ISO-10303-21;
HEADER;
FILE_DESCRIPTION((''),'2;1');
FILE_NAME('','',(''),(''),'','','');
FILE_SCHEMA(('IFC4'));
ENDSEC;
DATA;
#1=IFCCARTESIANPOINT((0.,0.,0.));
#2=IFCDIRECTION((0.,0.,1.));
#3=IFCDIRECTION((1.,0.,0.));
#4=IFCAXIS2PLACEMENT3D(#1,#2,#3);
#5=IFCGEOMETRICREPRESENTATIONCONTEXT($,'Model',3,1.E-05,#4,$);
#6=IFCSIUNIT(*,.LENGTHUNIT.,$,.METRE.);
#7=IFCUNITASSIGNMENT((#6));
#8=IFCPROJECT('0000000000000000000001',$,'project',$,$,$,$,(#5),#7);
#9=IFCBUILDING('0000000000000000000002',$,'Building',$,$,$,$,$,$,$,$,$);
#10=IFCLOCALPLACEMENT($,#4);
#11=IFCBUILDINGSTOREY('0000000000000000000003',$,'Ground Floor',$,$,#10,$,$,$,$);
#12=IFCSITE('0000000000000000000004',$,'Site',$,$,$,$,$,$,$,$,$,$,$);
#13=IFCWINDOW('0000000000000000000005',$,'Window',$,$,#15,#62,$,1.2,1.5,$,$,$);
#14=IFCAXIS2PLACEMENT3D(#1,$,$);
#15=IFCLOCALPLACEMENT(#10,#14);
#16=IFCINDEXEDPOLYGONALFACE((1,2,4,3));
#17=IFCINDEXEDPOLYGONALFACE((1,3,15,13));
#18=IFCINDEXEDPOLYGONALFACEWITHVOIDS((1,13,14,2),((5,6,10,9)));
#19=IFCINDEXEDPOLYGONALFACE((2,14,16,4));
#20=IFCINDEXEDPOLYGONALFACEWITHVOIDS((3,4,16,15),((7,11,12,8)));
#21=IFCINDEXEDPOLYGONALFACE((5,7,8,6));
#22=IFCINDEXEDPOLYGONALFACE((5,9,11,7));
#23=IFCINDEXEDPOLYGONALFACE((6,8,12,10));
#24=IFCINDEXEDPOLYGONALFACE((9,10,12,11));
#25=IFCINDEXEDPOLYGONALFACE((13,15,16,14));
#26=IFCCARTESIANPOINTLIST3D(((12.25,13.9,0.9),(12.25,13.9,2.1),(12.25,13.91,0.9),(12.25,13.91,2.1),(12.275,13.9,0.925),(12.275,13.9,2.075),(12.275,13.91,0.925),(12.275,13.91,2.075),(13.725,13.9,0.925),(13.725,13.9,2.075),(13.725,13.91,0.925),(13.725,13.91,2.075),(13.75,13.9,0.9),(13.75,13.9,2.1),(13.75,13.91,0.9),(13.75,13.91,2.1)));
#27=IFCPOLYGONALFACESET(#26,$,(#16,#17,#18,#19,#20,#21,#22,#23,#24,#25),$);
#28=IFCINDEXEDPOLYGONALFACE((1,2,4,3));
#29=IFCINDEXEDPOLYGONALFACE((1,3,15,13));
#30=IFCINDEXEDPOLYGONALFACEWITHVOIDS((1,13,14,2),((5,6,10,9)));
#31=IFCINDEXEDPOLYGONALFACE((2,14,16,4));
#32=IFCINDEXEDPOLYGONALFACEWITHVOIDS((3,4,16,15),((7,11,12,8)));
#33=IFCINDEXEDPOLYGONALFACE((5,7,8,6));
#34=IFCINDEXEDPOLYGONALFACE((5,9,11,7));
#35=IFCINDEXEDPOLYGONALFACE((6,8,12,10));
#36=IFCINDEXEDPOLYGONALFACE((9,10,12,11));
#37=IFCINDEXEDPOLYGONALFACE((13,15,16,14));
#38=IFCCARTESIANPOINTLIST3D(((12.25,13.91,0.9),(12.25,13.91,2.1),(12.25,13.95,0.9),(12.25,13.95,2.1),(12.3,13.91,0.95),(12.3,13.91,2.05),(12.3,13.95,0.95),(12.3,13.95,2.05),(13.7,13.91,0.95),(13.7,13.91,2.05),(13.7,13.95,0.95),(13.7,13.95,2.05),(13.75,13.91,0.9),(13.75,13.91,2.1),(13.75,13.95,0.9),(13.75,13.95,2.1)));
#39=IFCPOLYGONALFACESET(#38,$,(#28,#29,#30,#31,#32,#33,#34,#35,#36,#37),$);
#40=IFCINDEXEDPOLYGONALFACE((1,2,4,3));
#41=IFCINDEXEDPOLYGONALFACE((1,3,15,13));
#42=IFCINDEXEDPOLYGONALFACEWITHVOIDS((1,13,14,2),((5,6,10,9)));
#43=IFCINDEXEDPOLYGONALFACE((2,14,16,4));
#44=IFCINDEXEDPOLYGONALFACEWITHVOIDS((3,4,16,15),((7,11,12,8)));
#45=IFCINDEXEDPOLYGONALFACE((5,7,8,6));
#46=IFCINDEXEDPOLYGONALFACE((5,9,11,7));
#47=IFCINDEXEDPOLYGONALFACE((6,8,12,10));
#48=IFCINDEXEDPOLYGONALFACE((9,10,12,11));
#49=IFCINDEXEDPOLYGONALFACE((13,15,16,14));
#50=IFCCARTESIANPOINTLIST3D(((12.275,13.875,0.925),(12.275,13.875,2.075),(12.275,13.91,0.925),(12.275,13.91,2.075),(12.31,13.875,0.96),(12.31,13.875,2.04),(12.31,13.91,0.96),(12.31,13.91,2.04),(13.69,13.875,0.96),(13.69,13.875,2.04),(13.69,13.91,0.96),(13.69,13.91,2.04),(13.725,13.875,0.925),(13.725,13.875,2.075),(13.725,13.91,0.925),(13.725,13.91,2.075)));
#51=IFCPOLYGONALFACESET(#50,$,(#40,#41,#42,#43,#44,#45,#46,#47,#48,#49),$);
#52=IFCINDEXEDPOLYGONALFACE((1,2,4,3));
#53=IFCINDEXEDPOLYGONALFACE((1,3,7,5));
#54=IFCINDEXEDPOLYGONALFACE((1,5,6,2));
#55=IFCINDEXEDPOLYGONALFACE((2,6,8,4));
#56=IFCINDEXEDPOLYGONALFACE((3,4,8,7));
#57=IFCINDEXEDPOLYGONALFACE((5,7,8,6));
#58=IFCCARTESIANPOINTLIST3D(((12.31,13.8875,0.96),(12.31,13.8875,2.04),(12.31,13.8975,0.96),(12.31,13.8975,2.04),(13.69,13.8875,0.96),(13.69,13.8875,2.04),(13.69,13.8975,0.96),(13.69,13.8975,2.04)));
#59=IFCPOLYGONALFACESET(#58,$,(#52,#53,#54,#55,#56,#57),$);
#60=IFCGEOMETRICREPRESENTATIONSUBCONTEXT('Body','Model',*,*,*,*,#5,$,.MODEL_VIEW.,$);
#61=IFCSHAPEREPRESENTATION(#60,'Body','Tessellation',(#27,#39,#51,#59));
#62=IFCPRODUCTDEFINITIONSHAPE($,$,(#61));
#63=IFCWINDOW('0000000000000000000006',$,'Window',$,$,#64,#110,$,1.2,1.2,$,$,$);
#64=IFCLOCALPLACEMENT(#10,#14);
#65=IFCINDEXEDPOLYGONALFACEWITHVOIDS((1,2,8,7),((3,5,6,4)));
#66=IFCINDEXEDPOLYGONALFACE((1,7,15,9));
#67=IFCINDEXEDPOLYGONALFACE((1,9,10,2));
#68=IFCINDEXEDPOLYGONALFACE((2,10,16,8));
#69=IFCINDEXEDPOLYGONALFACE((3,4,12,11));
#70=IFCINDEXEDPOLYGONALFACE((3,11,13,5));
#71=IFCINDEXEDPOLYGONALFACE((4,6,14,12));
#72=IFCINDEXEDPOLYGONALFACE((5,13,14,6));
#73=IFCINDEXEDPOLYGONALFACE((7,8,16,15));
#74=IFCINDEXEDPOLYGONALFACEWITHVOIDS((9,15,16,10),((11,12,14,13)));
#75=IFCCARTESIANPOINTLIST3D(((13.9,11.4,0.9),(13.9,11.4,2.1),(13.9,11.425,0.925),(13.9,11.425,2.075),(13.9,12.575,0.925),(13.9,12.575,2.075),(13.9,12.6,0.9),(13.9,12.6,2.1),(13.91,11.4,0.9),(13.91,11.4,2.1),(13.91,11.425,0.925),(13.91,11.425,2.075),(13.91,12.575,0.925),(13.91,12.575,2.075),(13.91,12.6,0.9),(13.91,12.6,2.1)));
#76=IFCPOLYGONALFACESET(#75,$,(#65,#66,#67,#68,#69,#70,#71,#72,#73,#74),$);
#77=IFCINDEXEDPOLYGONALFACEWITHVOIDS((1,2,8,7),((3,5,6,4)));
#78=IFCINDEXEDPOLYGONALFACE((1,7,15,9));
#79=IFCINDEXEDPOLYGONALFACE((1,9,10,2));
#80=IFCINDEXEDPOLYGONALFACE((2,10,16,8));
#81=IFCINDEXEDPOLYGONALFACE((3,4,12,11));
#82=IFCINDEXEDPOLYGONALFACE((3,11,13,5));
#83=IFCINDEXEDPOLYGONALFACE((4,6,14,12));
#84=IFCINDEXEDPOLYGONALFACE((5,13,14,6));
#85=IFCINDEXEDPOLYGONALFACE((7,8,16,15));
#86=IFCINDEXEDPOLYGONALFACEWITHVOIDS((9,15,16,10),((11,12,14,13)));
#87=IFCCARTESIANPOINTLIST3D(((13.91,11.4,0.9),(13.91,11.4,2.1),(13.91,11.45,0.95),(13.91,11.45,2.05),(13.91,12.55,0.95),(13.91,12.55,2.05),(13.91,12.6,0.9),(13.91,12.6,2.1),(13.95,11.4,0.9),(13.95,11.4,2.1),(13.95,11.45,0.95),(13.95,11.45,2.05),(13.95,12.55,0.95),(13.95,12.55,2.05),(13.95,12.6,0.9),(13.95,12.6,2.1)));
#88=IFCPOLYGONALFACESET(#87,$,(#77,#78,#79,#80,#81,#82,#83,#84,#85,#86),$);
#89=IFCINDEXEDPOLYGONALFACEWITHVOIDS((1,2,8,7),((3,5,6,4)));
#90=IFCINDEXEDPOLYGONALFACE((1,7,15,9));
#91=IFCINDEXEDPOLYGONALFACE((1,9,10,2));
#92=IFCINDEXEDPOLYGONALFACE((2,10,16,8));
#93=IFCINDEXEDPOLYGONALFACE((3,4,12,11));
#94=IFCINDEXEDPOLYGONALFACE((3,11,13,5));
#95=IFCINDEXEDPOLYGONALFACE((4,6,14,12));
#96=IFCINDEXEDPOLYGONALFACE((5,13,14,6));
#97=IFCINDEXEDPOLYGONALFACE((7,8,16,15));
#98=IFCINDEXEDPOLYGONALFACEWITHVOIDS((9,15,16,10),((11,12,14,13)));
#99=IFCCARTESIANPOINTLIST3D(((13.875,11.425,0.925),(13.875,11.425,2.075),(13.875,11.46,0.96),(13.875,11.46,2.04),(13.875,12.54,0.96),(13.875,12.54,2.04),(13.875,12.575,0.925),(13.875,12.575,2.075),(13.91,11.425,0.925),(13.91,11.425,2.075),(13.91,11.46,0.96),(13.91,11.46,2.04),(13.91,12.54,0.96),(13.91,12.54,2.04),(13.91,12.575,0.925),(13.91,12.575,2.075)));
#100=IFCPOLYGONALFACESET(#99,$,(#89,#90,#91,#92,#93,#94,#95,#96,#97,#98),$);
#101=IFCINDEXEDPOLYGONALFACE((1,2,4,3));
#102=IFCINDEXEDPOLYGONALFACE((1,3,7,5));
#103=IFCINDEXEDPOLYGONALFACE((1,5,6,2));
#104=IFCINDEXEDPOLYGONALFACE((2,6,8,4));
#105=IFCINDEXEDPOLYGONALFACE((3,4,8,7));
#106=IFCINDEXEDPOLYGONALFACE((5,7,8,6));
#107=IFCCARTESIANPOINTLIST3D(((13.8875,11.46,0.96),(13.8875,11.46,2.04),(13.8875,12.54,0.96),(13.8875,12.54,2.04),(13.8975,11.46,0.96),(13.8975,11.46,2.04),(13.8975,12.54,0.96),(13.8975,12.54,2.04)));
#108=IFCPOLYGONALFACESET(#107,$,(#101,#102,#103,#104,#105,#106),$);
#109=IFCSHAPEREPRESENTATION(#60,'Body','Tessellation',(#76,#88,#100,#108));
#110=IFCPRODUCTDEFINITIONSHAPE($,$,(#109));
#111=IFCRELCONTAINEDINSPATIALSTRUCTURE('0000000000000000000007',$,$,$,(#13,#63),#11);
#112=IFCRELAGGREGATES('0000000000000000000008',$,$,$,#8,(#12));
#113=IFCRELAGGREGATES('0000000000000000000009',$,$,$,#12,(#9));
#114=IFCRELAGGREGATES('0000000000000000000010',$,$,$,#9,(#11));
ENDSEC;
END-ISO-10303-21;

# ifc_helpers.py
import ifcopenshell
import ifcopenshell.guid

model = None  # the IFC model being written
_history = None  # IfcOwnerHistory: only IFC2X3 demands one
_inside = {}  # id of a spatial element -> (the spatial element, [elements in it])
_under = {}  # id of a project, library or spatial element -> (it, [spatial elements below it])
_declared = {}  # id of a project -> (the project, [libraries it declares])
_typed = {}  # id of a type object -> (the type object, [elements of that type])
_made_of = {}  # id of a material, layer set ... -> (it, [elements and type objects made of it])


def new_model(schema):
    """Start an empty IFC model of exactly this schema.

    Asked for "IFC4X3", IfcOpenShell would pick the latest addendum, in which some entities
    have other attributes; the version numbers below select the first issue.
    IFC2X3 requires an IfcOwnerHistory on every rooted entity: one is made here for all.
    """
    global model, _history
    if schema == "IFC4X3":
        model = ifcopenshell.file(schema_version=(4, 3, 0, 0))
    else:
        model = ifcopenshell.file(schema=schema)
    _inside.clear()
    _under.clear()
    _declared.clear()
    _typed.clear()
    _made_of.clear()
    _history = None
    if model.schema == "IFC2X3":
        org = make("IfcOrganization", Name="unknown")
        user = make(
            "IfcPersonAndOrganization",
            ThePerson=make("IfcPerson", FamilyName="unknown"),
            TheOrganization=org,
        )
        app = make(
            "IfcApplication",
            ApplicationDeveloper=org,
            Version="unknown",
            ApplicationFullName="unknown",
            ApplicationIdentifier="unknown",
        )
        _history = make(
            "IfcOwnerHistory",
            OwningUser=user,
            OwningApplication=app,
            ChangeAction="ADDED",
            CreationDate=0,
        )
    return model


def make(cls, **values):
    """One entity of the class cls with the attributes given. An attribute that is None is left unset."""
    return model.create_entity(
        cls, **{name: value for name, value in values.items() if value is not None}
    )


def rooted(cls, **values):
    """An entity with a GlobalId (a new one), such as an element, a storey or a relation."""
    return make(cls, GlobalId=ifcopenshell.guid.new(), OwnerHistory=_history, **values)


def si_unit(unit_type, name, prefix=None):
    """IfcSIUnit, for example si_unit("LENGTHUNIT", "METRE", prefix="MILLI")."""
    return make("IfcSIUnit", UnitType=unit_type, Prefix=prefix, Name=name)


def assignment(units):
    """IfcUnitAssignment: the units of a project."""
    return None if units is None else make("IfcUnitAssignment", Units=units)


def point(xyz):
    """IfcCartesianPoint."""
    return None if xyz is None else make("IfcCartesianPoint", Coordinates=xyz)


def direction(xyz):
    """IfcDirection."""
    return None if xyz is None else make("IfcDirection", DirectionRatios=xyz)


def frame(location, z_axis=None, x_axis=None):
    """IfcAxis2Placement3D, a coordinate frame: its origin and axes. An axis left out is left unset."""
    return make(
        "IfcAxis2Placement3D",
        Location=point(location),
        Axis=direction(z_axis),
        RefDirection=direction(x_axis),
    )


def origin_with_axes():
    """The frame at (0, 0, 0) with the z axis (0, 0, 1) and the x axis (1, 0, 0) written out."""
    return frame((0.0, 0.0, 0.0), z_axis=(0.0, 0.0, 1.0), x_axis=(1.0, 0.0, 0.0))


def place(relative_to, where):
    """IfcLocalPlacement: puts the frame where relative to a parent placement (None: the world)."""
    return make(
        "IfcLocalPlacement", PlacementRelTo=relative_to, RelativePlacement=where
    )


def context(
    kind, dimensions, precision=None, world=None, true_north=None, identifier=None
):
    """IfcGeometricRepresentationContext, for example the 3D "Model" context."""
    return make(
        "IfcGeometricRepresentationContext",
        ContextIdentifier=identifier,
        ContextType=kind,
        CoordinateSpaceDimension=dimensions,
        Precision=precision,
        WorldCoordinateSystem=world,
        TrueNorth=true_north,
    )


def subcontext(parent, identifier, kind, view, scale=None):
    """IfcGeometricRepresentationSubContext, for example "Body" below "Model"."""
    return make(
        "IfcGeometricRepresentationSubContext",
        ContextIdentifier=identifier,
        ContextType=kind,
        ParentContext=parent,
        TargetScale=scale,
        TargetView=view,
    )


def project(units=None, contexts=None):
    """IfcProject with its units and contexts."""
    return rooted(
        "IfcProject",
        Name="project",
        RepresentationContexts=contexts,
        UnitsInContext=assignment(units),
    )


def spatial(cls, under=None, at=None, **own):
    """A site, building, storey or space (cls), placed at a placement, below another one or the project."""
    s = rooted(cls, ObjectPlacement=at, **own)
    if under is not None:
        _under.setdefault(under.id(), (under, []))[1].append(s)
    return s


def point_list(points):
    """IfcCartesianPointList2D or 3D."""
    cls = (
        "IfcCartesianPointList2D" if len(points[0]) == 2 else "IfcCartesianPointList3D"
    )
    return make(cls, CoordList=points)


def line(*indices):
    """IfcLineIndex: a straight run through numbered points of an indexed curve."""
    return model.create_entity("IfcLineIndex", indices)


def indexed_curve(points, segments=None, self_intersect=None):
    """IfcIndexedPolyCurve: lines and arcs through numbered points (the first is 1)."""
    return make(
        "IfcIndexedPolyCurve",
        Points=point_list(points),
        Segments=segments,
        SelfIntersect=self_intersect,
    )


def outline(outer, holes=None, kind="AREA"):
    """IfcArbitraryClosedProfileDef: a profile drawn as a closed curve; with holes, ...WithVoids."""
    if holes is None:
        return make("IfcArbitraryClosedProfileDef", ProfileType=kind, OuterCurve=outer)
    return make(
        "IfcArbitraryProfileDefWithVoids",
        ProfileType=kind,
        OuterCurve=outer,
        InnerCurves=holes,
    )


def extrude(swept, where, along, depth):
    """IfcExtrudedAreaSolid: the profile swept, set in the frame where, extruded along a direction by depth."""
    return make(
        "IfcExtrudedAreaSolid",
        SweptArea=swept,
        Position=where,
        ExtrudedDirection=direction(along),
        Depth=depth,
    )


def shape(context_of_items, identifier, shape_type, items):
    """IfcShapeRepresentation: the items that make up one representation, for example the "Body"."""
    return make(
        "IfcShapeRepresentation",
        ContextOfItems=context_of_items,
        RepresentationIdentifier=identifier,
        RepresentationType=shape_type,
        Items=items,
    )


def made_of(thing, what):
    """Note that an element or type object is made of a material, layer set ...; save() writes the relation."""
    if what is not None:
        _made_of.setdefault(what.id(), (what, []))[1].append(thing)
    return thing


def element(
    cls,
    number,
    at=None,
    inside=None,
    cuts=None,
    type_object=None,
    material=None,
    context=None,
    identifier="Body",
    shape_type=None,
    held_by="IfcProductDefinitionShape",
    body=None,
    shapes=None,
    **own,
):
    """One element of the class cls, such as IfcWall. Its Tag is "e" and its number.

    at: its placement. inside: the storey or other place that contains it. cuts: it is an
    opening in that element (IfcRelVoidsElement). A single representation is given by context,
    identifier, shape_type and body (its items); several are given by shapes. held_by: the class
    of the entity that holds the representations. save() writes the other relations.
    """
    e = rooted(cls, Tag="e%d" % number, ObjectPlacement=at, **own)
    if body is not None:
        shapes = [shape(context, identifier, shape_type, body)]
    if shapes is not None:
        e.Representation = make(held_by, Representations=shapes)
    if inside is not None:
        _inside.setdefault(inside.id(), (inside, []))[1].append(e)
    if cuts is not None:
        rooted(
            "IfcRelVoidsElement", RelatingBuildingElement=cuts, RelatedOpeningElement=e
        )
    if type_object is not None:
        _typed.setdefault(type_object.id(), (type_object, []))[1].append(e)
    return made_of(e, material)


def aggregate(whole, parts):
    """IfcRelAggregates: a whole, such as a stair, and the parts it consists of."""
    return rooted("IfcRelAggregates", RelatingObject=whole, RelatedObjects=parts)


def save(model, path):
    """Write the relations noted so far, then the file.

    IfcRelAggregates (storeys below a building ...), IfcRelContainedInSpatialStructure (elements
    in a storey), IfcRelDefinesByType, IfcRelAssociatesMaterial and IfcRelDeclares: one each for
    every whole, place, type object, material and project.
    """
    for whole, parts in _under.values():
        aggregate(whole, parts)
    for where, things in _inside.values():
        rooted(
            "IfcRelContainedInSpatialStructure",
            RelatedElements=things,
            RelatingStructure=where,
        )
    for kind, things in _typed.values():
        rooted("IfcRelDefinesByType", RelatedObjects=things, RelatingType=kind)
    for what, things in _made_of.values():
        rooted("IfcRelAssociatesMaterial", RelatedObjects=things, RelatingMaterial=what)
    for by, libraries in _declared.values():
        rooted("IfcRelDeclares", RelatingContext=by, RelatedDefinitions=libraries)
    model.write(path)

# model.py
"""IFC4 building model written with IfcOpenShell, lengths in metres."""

from ifc_helpers import new_model, si_unit, frame, origin_with_axes, place, context, subcontext, project, spatial, line, indexed_curve, outline, extrude, element, save


model = new_model("IFC4")

# Units and contexts
model_context = context("Model", 3, precision=1e-05, world=origin_with_axes())
body_context = subcontext(model_context, "Body", "Model", "MODEL_VIEW")
ifc_project = project(units=[si_unit("LENGTHUNIT", "METRE")], contexts=[model_context])

# Site, building, storey
site = spatial("IfcSite", under=ifc_project, Name="Site")
building = spatial("IfcBuilding", under=site, Name="Building")
storey_placement = place(None, origin_with_axes())
storey = spatial("IfcBuildingStorey", under=building, at=storey_placement, Name="Ground Floor")

# Windows
window_1_placement = place(storey_placement, frame((13.75, 14.0, 0.9), z_axis=(0.0, 0.0, 1.0), x_axis=(-1.0, 0.0, 0.0)))
element("IfcWindow", 1, at=window_1_placement, inside=storey, Name="Window", OverallHeight=1.2, OverallWidth=1.5, context=body_context, shape_type="SweptSolid", body=[
    extrude(outline(indexed_curve([(0.0, 0.0), (1.5, 0.0), (1.5, 1.2), (0.0, 1.2)], segments=[line(1, 2, 3, 4, 1)]), holes=[indexed_curve([(0.025, 0.025), (1.475, 0.025), (1.475, 1.175), (0.025, 1.175)], segments=[line(1, 2, 3, 4, 1)])]), frame((0.0, 0.09, 0.0), z_axis=(0.0, -1.0, 0.0), x_axis=(1.0, 0.0, 0.0)), (0.0, 0.0, -1.0), 0.01),
    extrude(outline(indexed_curve([(0.0, 0.0), (1.5, 0.0), (1.5, 1.2), (0.0, 1.2)], segments=[line(1, 2, 3, 4, 1)]), holes=[indexed_curve([(0.05, 0.05), (1.45, 0.05), (1.45, 1.15), (0.05, 1.15)], segments=[line(1, 2, 3, 4, 1)])]), frame((0.0, 0.05, 0.0), z_axis=(0.0, -1.0, 0.0), x_axis=(1.0, 0.0, 0.0)), (0.0, 0.0, -1.0), 0.04),
    extrude(outline(indexed_curve([(0.0, 0.0), (1.45, 0.0), (1.45, 1.15), (0.0, 1.15)], segments=[line(1, 2, 3, 4, 1)]), holes=[indexed_curve([(0.035, 0.035), (1.415, 0.035), (1.415, 1.115), (0.035, 1.115)], segments=[line(1, 2, 3, 4, 1)])]), frame((0.025, 0.09, 0.025), z_axis=(0.0, -1.0, 0.0), x_axis=(1.0, 0.0, 0.0)), (0.0, 0.0, -1.0), 0.035),
    extrude(outline(indexed_curve([(0.035, 0.035), (1.415, 0.035), (1.415, 1.115), (0.035, 1.115)], segments=[line(1, 2, 3, 4, 1)])), frame((0.025, 0.1025, 0.025), z_axis=(0.0, -1.0, 0.0), x_axis=(1.0, 0.0, 0.0)), (0.0, 0.0, -1.0), 0.01),
])
window_2_placement = place(storey_placement, frame((14.0, 11.4, 0.9), z_axis=(0.0, 0.0, 1.0), x_axis=(0.0, 1.0, 0.0)))
element("IfcWindow", 2, at=window_2_placement, inside=storey, Name="Window", OverallHeight=1.2, OverallWidth=1.2, context=body_context, shape_type="SweptSolid", body=[
    extrude(outline(indexed_curve([(0.0, 0.0), (1.2, 0.0), (1.2, 1.2), (0.0, 1.2)], segments=[line(1, 2, 3, 4, 1)]), holes=[indexed_curve([(0.025, 0.025), (1.175, 0.025), (1.175, 1.175), (0.025, 1.175)], segments=[line(1, 2, 3, 4, 1)])]), frame((0.0, 0.09, 0.0), z_axis=(0.0, -1.0, 0.0), x_axis=(1.0, 0.0, 0.0)), (0.0, 0.0, -1.0), 0.01),
    extrude(outline(indexed_curve([(0.0, 0.0), (1.2, 0.0), (1.2, 1.2), (0.0, 1.2)], segments=[line(1, 2, 3, 4, 1)]), holes=[indexed_curve([(0.05, 0.05), (1.15, 0.05), (1.15, 1.15), (0.05, 1.15)], segments=[line(1, 2, 3, 4, 1)])]), frame((0.0, 0.05, 0.0), z_axis=(0.0, -1.0, 0.0), x_axis=(1.0, 0.0, 0.0)), (0.0, 0.0, -1.0), 0.04),
    extrude(outline(indexed_curve([(0.0, 0.0), (1.15, 0.0), (1.15, 1.15), (0.0, 1.15)], segments=[line(1, 2, 3, 4, 1)]), holes=[indexed_curve([(0.035, 0.035), (1.115, 0.035), (1.115, 1.115), (0.035, 1.115)], segments=[line(1, 2, 3, 4, 1)])]), frame((0.025, 0.09, 0.025), z_axis=(0.0, -1.0, 0.0), x_axis=(1.0, 0.0, 0.0)), (0.0, 0.0, -1.0), 0.035),
    extrude(outline(indexed_curve([(0.035, 0.035), (1.115, 0.035), (1.115, 1.115), (0.035, 1.115)], segments=[line(1, 2, 3, 4, 1)])), frame((0.025, 0.1025, 0.025), z_axis=(0.0, -1.0, 0.0), x_axis=(1.0, 0.0, 0.0)), (0.0, 0.0, -1.0), 0.01),
])

save(model, "model.ifc")
